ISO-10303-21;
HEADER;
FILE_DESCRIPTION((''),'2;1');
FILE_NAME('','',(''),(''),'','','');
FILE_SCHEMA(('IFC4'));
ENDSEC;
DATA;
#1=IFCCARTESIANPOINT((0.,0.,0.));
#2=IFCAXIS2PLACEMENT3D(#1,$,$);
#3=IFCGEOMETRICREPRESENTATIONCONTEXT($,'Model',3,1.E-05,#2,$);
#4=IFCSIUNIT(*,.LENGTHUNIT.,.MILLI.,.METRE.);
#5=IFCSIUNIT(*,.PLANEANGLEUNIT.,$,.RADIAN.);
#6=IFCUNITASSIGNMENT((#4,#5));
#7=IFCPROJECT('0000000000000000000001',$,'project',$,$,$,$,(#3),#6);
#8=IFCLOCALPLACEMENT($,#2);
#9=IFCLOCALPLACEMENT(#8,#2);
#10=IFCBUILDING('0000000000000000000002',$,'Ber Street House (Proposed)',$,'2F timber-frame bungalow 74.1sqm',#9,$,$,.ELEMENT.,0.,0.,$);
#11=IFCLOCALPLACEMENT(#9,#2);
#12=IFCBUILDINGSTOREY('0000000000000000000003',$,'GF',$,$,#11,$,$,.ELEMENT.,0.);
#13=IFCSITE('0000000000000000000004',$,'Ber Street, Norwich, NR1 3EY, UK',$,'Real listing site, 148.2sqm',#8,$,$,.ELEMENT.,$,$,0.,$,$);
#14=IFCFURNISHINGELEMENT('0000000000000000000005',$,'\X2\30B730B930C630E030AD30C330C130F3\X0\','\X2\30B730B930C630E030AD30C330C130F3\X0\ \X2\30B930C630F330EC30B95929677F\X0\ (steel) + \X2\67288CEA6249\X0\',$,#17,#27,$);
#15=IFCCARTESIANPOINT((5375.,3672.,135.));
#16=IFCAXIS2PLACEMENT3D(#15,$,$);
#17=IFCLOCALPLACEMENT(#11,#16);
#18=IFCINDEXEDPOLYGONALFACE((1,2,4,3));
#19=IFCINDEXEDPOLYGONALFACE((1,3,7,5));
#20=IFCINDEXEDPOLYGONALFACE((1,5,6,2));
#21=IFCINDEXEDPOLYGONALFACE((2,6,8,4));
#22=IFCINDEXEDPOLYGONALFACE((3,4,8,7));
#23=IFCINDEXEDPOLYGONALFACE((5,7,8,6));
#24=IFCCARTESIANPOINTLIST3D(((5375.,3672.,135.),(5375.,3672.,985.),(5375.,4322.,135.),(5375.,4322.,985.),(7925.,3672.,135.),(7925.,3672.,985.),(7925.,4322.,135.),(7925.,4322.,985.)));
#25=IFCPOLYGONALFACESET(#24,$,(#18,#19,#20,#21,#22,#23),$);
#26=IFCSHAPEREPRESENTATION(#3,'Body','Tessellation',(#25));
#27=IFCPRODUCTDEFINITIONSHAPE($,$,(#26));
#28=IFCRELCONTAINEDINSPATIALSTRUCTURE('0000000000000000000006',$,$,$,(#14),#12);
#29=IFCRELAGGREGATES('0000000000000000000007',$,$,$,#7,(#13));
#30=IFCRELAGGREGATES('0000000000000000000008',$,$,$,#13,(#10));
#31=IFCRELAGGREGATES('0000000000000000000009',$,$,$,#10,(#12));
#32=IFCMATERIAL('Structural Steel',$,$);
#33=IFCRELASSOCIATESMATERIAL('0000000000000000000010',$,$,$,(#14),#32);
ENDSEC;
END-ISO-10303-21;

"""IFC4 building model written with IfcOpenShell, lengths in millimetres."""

from ifc_helpers import new_model, si_unit, frame, frame_2d, origin, place, context, project, spatial, rectangle, extrude, material, element, save


model = new_model("IFC4")

# Units and contexts
model_context = context("Model", 3, precision=1e-05, world=origin())
ifc_project = project(units=[si_unit("LENGTHUNIT", "METRE", prefix="MILLI"), si_unit("PLANEANGLEUNIT", "RADIAN")], contexts=[model_context])

# Site, building, storey
site_placement = place(None, origin())
site = spatial("IfcSite", under=ifc_project, at=site_placement, Name="Ber Street, Norwich, NR1 3EY, UK", ObjectType="Real listing site, 148.2sqm", CompositionType="ELEMENT", RefElevation=0.0)
building_placement = place(site_placement, origin())
building = spatial("IfcBuilding", under=site, at=building_placement, Name="Ber Street House (Proposed)", ObjectType="2F timber-frame bungalow 74.1sqm", CompositionType="ELEMENT", ElevationOfRefHeight=0.0, ElevationOfTerrain=0.0)
storey_placement = place(building_placement, origin())
storey = spatial("IfcBuildingStorey", under=building, at=storey_placement, Name="GF", CompositionType="ELEMENT", Elevation=0.0)

# Furnishing element
ifc_material_1 = material(Name="Structural Steel")
furnishing_1_placement = place(storey_placement, frame((5375.0, 3672.0, 135.0)))
element("IfcFurnishingElement", 1, at=furnishing_1_placement, inside=storey, material=ifc_material_1, Name="システムキッチン", Description="システムキッチン ステンレス天板 (steel) + 木質扉", context=model_context, shape_type="SweptSolid", body=[
    extrude(rectangle(XDim=2550.0, YDim=650.0, at=frame_2d((1275.0, 325.0))), frame((5375.0, 3672.0, 135.0)), (0.0, 0.0, 1.0), 850.0),
])

save(model, "model.ifc")
